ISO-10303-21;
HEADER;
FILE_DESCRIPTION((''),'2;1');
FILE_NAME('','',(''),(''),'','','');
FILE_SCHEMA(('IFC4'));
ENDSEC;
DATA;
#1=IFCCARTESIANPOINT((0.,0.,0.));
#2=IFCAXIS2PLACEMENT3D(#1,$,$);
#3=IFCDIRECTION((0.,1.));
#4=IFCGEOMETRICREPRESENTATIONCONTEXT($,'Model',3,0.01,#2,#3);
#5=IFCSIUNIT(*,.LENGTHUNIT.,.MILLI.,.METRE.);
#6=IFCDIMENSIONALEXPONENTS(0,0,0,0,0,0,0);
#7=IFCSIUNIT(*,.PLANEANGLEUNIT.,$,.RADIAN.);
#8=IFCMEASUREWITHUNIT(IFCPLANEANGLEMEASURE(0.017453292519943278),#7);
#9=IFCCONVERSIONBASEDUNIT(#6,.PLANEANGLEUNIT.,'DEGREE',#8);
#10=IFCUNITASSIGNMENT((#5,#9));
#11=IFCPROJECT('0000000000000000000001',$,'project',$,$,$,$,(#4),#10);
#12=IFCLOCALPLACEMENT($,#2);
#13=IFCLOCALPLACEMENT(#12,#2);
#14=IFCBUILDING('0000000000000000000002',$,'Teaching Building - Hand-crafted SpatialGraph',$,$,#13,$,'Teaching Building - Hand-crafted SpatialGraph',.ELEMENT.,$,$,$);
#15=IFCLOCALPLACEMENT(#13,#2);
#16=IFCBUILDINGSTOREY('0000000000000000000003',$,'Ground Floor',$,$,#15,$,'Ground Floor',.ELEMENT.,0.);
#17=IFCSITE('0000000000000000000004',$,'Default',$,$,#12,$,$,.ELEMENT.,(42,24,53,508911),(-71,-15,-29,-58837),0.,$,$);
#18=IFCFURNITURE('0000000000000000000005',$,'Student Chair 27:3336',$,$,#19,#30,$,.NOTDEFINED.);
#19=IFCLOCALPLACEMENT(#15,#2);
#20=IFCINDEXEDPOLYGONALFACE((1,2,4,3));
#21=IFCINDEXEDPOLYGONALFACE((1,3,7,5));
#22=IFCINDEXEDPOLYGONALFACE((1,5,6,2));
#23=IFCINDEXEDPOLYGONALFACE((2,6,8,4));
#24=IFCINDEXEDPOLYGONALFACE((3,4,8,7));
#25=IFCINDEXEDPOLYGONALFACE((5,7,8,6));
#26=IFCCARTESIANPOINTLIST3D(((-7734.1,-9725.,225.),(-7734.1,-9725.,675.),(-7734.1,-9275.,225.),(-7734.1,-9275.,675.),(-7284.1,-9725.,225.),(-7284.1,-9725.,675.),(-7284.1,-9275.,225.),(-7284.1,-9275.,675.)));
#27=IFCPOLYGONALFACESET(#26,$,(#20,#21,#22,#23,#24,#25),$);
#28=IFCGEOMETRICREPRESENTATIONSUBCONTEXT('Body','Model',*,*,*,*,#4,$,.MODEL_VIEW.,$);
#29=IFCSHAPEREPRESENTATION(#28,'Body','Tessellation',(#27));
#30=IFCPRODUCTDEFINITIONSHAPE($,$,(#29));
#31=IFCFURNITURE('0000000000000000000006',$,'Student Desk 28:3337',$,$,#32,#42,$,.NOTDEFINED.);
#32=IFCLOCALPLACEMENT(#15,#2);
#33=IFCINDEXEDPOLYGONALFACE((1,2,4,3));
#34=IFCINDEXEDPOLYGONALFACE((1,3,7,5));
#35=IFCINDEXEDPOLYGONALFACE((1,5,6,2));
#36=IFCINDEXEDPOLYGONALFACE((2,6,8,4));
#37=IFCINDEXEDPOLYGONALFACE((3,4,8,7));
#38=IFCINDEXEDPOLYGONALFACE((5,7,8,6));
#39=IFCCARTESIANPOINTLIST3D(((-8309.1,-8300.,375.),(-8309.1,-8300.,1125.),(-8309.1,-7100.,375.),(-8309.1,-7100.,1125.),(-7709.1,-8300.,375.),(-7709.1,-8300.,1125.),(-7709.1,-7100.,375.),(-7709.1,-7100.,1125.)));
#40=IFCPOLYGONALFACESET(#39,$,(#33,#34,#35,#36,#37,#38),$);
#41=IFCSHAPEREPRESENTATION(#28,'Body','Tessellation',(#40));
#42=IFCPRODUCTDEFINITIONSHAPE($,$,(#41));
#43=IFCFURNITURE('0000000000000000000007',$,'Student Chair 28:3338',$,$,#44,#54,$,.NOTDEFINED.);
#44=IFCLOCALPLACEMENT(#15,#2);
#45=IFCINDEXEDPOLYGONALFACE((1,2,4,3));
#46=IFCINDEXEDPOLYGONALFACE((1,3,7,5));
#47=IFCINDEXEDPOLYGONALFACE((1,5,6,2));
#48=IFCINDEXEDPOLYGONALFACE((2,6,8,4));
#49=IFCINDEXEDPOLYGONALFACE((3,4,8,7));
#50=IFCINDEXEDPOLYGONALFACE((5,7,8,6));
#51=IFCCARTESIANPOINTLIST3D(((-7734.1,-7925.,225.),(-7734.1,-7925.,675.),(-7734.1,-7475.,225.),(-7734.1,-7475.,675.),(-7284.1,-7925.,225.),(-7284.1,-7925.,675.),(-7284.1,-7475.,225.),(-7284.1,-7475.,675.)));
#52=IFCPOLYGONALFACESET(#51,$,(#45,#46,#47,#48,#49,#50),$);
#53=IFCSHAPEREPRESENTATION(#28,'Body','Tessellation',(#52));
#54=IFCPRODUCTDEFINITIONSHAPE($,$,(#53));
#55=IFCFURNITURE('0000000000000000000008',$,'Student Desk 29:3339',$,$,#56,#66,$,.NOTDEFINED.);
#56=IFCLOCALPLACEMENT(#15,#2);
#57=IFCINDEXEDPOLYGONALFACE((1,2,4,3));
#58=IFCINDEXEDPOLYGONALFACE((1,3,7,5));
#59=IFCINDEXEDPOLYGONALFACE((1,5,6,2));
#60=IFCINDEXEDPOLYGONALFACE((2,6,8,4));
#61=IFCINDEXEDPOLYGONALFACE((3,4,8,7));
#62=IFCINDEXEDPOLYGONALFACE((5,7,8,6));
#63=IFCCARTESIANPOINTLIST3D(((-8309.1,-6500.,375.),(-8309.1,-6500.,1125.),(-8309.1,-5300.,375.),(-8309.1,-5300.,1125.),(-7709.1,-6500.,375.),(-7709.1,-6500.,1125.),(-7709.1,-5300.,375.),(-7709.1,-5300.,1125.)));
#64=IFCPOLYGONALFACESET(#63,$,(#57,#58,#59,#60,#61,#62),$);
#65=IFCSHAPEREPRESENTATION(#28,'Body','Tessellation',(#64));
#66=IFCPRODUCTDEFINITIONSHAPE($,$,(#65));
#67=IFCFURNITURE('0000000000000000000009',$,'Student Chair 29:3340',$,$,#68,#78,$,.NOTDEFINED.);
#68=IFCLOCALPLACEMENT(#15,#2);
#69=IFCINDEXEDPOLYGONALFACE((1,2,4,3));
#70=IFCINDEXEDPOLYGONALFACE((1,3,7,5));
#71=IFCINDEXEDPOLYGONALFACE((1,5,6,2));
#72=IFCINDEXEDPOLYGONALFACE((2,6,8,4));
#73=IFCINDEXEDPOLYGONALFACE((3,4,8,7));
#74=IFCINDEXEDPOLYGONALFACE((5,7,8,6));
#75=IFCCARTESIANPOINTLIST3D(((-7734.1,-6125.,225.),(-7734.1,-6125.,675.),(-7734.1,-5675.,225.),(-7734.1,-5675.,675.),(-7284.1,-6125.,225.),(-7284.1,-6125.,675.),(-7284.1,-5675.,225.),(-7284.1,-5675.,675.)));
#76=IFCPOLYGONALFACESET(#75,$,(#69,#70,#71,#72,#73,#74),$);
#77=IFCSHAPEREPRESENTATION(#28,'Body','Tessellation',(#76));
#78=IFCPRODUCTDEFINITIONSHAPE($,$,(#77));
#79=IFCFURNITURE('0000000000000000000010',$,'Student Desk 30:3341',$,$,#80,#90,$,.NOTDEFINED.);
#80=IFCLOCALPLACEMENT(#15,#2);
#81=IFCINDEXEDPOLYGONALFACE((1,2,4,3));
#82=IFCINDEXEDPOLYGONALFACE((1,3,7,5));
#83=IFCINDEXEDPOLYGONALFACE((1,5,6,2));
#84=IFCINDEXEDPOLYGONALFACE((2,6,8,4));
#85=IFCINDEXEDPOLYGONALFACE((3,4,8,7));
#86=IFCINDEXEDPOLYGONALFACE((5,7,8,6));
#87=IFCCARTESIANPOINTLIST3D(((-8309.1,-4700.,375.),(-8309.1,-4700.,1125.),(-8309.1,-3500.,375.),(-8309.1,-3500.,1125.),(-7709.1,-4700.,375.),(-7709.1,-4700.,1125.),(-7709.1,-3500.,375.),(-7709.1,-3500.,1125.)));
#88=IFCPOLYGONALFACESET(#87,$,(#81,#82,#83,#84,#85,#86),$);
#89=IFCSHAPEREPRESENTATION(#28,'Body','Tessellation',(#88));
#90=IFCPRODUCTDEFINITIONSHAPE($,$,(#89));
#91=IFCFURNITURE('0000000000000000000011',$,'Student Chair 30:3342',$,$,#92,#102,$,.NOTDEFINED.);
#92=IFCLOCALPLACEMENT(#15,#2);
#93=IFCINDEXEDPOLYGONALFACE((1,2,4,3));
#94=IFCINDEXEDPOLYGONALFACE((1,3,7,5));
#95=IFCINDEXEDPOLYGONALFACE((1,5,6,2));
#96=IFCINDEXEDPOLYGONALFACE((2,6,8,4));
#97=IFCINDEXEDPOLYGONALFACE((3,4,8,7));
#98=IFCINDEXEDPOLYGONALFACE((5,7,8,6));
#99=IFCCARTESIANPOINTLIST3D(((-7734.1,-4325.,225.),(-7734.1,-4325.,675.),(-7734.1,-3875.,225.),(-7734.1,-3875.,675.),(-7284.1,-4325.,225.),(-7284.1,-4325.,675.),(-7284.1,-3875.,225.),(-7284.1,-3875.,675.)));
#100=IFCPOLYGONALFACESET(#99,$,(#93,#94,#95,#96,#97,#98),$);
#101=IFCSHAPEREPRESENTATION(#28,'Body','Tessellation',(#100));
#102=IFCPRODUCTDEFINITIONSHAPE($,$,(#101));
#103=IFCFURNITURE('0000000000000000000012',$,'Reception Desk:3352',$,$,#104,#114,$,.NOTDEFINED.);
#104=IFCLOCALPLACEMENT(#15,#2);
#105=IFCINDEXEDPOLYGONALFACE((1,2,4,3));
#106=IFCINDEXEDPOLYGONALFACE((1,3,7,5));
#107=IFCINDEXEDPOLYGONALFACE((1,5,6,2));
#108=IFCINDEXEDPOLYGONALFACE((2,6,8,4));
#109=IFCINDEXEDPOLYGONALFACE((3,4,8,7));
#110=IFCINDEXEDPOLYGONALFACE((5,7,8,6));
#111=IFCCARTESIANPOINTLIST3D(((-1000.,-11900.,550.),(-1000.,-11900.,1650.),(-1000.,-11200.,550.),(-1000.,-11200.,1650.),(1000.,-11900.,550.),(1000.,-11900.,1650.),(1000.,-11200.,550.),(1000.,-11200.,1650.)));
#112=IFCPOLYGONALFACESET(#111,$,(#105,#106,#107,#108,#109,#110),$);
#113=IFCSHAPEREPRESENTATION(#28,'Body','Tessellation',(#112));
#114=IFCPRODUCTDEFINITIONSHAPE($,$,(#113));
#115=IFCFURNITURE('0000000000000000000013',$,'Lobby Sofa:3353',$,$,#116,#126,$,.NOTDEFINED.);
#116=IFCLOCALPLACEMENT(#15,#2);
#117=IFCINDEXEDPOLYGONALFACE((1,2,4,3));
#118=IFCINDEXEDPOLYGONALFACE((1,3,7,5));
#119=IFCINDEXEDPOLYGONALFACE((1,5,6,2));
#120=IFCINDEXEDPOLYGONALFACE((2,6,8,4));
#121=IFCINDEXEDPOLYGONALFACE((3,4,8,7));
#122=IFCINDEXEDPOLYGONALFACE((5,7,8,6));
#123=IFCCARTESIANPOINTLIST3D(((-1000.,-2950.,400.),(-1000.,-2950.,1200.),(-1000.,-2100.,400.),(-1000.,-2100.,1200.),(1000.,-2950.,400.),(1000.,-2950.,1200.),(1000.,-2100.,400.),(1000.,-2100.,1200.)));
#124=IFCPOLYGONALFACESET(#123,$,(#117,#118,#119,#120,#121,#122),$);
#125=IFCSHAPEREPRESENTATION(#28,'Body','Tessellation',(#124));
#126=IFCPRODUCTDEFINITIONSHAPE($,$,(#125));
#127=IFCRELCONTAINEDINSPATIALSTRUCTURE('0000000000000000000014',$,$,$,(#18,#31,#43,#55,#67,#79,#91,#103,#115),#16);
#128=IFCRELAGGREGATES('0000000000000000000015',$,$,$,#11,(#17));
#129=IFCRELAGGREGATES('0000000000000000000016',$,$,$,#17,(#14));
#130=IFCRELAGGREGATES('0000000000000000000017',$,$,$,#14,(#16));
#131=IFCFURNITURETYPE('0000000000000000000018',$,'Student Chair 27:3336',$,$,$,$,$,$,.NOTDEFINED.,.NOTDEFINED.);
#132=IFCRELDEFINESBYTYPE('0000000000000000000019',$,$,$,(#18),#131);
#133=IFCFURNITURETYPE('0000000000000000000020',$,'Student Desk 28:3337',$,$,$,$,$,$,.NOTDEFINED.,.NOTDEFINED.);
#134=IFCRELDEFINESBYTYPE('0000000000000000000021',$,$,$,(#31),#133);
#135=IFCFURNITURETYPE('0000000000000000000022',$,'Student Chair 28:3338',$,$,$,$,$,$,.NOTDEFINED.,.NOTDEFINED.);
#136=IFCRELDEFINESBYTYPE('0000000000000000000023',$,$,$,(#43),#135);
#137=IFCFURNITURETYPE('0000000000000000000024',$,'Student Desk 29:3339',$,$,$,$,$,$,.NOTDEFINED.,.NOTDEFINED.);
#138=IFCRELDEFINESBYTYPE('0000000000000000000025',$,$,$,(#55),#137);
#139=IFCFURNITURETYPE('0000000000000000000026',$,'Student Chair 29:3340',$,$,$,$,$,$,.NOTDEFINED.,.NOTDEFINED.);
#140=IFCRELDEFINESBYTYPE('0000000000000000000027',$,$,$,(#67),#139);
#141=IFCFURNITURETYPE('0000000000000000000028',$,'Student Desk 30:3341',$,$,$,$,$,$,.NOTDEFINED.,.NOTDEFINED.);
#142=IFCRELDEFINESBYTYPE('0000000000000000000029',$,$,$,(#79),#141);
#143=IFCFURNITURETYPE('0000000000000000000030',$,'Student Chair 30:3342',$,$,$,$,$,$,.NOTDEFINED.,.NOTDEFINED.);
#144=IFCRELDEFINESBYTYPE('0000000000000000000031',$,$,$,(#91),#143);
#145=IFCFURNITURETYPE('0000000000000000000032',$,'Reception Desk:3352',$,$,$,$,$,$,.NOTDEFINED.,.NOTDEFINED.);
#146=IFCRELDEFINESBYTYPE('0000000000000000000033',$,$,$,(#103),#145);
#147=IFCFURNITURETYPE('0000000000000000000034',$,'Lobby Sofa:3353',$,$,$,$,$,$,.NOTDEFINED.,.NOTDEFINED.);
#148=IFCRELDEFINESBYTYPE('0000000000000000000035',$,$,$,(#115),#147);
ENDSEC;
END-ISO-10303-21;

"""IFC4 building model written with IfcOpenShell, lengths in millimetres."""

from ifc_helpers import new_model, entity, si_unit, converted_unit, direction, frame, frame_2d, origin, origin_2d_with_axis, place, context, subcontext, project, spatial, rectangle, extrude, type_object, element, save


model = new_model("IFC4")

# Units and contexts
model_context = context("Model", 3, precision=0.01, world=origin(), true_north=direction((0.0, 1.0)))
body_context = subcontext(model_context, "Body", "Model", "MODEL_VIEW")
ifc_project = project(units=[si_unit("LENGTHUNIT", "METRE", prefix="MILLI"), converted_unit("PLANEANGLEUNIT", "DEGREE", entity("IfcPlaneAngleMeasure", 0.017453292519943278), si_unit("PLANEANGLEUNIT", "RADIAN"), dimensions=[0, 0, 0, 0, 0, 0, 0])], contexts=[model_context])

# Site, building, storey
site_placement = place(None, origin())
site = spatial("IfcSite", under=ifc_project, at=site_placement, Name="Default", CompositionType="ELEMENT", RefLatitude=(42, 24, 53, 508911), RefLongitude=(-71, -15, -29, -58837), RefElevation=0.0)
building_placement = place(site_placement, origin())
building = spatial("IfcBuilding", under=site, at=building_placement, Name="Teaching Building - Hand-crafted SpatialGraph", LongName="Teaching Building - Hand-crafted SpatialGraph", CompositionType="ELEMENT")
storey_placement = place(building_placement, origin())
storey = spatial("IfcBuildingStorey", under=building, at=storey_placement, Name="Ground Floor", LongName="Ground Floor", CompositionType="ELEMENT", Elevation=0.0)

# Furniture
furniture_type_1 = type_object("IfcFurnitureType", Name="Student Chair 27:3336", PredefinedType="NOTDEFINED")
furniture_1_placement = place(storey_placement, origin())
element("IfcFurniture", 1, at=furniture_1_placement, inside=storey, type_object=furniture_type_1, Name="Student Chair 27:3336", PredefinedType="NOTDEFINED", context=body_context, shape_type="SweptSolid", body=[
    extrude(rectangle(XDim=450.0, YDim=450.0, at=origin_2d_with_axis()), frame((-7509.1, -9500.0, 225.0)), (0.0, 0.0, 1.0), 450.0),
])
furniture_type_2 = type_object("IfcFurnitureType", Name="Student Desk 28:3337", PredefinedType="NOTDEFINED")
furniture_2_placement = place(storey_placement, origin())
element("IfcFurniture", 2, at=furniture_2_placement, inside=storey, type_object=furniture_type_2, Name="Student Desk 28:3337", PredefinedType="NOTDEFINED", context=body_context, shape_type="SweptSolid", body=[
    extrude(rectangle(XDim=1200.0, YDim=600.0, at=frame_2d((0.0, 0.0), x_axis=(1.0, 0.0))), frame((-8009.1, -7700.0, 375.0), z_axis=(0.0, 0.0, 1.0), x_axis=(0.0, 1.0, 0.0)), (0.0, 0.0, 1.0), 750.0),
])
furniture_type_3 = type_object("IfcFurnitureType", Name="Student Chair 28:3338", PredefinedType="NOTDEFINED")
furniture_3_placement = place(storey_placement, origin())
element("IfcFurniture", 3, at=furniture_3_placement, inside=storey, type_object=furniture_type_3, Name="Student Chair 28:3338", PredefinedType="NOTDEFINED", context=body_context, shape_type="SweptSolid", body=[
    extrude(rectangle(XDim=450.0, YDim=450.0, at=frame_2d((0.0, 0.0), x_axis=(1.0, 0.0))), frame((-7509.1, -7700.0, 225.0)), (0.0, 0.0, 1.0), 450.0),
])
furniture_type_4 = type_object("IfcFurnitureType", Name="Student Desk 29:3339", PredefinedType="NOTDEFINED")
furniture_4_placement = place(storey_placement, origin())
element("IfcFurniture", 4, at=furniture_4_placement, inside=storey, type_object=furniture_type_4, Name="Student Desk 29:3339", PredefinedType="NOTDEFINED", context=body_context, shape_type="SweptSolid", body=[
    extrude(rectangle(XDim=1200.0, YDim=600.0, at=frame_2d((0.0, 0.0), x_axis=(1.0, 0.0))), frame((-8009.1, -5900.0, 375.0), z_axis=(0.0, 0.0, 1.0), x_axis=(0.0, 1.0, 0.0)), (0.0, 0.0, 1.0), 750.0),
])
furniture_type_5 = type_object("IfcFurnitureType", Name="Student Chair 29:3340", PredefinedType="NOTDEFINED")
furniture_5_placement = place(storey_placement, origin())
element("IfcFurniture", 5, at=furniture_5_placement, inside=storey, type_object=furniture_type_5, Name="Student Chair 29:3340", PredefinedType="NOTDEFINED", context=body_context, shape_type="SweptSolid", body=[
    extrude(rectangle(XDim=450.0, YDim=450.0, at=origin_2d_with_axis()), frame((-7509.1, -5900.0, 225.0)), (0.0, 0.0, 1.0), 450.0),
])
furniture_type_6 = type_object("IfcFurnitureType", Name="Student Desk 30:3341", PredefinedType="NOTDEFINED")
furniture_6_placement = place(storey_placement, origin())
element("IfcFurniture", 6, at=furniture_6_placement, inside=storey, type_object=furniture_type_6, Name="Student Desk 30:3341", PredefinedType="NOTDEFINED", context=body_context, shape_type="SweptSolid", body=[
    extrude(rectangle(XDim=1200.0, YDim=600.0, at=frame_2d((0.0, 0.0), x_axis=(1.0, 0.0))), frame((-8009.1, -4100.0, 375.0), z_axis=(0.0, 0.0, 1.0), x_axis=(0.0, 1.0, 0.0)), (0.0, 0.0, 1.0), 750.0),
])
furniture_type_7 = type_object("IfcFurnitureType", Name="Student Chair 30:3342", PredefinedType="NOTDEFINED")
furniture_7_placement = place(storey_placement, origin())
element("IfcFurniture", 7, at=furniture_7_placement, inside=storey, type_object=furniture_type_7, Name="Student Chair 30:3342", PredefinedType="NOTDEFINED", context=body_context, shape_type="SweptSolid", body=[
    extrude(rectangle(XDim=450.0, YDim=450.0, at=origin_2d_with_axis()), frame((-7509.1, -4100.0, 225.0)), (0.0, 0.0, 1.0), 450.0),
])
furniture_type_8 = type_object("IfcFurnitureType", Name="Reception Desk:3352", PredefinedType="NOTDEFINED")
furniture_8_placement = place(storey_placement, origin())
element("IfcFurniture", 8, at=furniture_8_placement, inside=storey, type_object=furniture_type_8, Name="Reception Desk:3352", PredefinedType="NOTDEFINED", context=body_context, shape_type="SweptSolid", body=[
    extrude(rectangle(XDim=2000.0, YDim=700.0, at=origin_2d_with_axis()), frame((0.0, -11550.0, 550.0)), (0.0, 0.0, 1.0), 1100.0),
])
furniture_type_9 = type_object("IfcFurnitureType", Name="Lobby Sofa:3353", PredefinedType="NOTDEFINED")
furniture_9_placement = place(storey_placement, origin())
element("IfcFurniture", 9, at=furniture_9_placement, inside=storey, type_object=furniture_type_9, Name="Lobby Sofa:3353", PredefinedType="NOTDEFINED", context=body_context, shape_type="SweptSolid", body=[
    extrude(rectangle(XDim=2000.0, YDim=850.0, at=frame_2d((0.0, 0.0), x_axis=(1.0, 0.0))), frame((0.0, -2525.0, 400.0)), (0.0, 0.0, 1.0), 800.0),
])

save(model, "model.ifc")
